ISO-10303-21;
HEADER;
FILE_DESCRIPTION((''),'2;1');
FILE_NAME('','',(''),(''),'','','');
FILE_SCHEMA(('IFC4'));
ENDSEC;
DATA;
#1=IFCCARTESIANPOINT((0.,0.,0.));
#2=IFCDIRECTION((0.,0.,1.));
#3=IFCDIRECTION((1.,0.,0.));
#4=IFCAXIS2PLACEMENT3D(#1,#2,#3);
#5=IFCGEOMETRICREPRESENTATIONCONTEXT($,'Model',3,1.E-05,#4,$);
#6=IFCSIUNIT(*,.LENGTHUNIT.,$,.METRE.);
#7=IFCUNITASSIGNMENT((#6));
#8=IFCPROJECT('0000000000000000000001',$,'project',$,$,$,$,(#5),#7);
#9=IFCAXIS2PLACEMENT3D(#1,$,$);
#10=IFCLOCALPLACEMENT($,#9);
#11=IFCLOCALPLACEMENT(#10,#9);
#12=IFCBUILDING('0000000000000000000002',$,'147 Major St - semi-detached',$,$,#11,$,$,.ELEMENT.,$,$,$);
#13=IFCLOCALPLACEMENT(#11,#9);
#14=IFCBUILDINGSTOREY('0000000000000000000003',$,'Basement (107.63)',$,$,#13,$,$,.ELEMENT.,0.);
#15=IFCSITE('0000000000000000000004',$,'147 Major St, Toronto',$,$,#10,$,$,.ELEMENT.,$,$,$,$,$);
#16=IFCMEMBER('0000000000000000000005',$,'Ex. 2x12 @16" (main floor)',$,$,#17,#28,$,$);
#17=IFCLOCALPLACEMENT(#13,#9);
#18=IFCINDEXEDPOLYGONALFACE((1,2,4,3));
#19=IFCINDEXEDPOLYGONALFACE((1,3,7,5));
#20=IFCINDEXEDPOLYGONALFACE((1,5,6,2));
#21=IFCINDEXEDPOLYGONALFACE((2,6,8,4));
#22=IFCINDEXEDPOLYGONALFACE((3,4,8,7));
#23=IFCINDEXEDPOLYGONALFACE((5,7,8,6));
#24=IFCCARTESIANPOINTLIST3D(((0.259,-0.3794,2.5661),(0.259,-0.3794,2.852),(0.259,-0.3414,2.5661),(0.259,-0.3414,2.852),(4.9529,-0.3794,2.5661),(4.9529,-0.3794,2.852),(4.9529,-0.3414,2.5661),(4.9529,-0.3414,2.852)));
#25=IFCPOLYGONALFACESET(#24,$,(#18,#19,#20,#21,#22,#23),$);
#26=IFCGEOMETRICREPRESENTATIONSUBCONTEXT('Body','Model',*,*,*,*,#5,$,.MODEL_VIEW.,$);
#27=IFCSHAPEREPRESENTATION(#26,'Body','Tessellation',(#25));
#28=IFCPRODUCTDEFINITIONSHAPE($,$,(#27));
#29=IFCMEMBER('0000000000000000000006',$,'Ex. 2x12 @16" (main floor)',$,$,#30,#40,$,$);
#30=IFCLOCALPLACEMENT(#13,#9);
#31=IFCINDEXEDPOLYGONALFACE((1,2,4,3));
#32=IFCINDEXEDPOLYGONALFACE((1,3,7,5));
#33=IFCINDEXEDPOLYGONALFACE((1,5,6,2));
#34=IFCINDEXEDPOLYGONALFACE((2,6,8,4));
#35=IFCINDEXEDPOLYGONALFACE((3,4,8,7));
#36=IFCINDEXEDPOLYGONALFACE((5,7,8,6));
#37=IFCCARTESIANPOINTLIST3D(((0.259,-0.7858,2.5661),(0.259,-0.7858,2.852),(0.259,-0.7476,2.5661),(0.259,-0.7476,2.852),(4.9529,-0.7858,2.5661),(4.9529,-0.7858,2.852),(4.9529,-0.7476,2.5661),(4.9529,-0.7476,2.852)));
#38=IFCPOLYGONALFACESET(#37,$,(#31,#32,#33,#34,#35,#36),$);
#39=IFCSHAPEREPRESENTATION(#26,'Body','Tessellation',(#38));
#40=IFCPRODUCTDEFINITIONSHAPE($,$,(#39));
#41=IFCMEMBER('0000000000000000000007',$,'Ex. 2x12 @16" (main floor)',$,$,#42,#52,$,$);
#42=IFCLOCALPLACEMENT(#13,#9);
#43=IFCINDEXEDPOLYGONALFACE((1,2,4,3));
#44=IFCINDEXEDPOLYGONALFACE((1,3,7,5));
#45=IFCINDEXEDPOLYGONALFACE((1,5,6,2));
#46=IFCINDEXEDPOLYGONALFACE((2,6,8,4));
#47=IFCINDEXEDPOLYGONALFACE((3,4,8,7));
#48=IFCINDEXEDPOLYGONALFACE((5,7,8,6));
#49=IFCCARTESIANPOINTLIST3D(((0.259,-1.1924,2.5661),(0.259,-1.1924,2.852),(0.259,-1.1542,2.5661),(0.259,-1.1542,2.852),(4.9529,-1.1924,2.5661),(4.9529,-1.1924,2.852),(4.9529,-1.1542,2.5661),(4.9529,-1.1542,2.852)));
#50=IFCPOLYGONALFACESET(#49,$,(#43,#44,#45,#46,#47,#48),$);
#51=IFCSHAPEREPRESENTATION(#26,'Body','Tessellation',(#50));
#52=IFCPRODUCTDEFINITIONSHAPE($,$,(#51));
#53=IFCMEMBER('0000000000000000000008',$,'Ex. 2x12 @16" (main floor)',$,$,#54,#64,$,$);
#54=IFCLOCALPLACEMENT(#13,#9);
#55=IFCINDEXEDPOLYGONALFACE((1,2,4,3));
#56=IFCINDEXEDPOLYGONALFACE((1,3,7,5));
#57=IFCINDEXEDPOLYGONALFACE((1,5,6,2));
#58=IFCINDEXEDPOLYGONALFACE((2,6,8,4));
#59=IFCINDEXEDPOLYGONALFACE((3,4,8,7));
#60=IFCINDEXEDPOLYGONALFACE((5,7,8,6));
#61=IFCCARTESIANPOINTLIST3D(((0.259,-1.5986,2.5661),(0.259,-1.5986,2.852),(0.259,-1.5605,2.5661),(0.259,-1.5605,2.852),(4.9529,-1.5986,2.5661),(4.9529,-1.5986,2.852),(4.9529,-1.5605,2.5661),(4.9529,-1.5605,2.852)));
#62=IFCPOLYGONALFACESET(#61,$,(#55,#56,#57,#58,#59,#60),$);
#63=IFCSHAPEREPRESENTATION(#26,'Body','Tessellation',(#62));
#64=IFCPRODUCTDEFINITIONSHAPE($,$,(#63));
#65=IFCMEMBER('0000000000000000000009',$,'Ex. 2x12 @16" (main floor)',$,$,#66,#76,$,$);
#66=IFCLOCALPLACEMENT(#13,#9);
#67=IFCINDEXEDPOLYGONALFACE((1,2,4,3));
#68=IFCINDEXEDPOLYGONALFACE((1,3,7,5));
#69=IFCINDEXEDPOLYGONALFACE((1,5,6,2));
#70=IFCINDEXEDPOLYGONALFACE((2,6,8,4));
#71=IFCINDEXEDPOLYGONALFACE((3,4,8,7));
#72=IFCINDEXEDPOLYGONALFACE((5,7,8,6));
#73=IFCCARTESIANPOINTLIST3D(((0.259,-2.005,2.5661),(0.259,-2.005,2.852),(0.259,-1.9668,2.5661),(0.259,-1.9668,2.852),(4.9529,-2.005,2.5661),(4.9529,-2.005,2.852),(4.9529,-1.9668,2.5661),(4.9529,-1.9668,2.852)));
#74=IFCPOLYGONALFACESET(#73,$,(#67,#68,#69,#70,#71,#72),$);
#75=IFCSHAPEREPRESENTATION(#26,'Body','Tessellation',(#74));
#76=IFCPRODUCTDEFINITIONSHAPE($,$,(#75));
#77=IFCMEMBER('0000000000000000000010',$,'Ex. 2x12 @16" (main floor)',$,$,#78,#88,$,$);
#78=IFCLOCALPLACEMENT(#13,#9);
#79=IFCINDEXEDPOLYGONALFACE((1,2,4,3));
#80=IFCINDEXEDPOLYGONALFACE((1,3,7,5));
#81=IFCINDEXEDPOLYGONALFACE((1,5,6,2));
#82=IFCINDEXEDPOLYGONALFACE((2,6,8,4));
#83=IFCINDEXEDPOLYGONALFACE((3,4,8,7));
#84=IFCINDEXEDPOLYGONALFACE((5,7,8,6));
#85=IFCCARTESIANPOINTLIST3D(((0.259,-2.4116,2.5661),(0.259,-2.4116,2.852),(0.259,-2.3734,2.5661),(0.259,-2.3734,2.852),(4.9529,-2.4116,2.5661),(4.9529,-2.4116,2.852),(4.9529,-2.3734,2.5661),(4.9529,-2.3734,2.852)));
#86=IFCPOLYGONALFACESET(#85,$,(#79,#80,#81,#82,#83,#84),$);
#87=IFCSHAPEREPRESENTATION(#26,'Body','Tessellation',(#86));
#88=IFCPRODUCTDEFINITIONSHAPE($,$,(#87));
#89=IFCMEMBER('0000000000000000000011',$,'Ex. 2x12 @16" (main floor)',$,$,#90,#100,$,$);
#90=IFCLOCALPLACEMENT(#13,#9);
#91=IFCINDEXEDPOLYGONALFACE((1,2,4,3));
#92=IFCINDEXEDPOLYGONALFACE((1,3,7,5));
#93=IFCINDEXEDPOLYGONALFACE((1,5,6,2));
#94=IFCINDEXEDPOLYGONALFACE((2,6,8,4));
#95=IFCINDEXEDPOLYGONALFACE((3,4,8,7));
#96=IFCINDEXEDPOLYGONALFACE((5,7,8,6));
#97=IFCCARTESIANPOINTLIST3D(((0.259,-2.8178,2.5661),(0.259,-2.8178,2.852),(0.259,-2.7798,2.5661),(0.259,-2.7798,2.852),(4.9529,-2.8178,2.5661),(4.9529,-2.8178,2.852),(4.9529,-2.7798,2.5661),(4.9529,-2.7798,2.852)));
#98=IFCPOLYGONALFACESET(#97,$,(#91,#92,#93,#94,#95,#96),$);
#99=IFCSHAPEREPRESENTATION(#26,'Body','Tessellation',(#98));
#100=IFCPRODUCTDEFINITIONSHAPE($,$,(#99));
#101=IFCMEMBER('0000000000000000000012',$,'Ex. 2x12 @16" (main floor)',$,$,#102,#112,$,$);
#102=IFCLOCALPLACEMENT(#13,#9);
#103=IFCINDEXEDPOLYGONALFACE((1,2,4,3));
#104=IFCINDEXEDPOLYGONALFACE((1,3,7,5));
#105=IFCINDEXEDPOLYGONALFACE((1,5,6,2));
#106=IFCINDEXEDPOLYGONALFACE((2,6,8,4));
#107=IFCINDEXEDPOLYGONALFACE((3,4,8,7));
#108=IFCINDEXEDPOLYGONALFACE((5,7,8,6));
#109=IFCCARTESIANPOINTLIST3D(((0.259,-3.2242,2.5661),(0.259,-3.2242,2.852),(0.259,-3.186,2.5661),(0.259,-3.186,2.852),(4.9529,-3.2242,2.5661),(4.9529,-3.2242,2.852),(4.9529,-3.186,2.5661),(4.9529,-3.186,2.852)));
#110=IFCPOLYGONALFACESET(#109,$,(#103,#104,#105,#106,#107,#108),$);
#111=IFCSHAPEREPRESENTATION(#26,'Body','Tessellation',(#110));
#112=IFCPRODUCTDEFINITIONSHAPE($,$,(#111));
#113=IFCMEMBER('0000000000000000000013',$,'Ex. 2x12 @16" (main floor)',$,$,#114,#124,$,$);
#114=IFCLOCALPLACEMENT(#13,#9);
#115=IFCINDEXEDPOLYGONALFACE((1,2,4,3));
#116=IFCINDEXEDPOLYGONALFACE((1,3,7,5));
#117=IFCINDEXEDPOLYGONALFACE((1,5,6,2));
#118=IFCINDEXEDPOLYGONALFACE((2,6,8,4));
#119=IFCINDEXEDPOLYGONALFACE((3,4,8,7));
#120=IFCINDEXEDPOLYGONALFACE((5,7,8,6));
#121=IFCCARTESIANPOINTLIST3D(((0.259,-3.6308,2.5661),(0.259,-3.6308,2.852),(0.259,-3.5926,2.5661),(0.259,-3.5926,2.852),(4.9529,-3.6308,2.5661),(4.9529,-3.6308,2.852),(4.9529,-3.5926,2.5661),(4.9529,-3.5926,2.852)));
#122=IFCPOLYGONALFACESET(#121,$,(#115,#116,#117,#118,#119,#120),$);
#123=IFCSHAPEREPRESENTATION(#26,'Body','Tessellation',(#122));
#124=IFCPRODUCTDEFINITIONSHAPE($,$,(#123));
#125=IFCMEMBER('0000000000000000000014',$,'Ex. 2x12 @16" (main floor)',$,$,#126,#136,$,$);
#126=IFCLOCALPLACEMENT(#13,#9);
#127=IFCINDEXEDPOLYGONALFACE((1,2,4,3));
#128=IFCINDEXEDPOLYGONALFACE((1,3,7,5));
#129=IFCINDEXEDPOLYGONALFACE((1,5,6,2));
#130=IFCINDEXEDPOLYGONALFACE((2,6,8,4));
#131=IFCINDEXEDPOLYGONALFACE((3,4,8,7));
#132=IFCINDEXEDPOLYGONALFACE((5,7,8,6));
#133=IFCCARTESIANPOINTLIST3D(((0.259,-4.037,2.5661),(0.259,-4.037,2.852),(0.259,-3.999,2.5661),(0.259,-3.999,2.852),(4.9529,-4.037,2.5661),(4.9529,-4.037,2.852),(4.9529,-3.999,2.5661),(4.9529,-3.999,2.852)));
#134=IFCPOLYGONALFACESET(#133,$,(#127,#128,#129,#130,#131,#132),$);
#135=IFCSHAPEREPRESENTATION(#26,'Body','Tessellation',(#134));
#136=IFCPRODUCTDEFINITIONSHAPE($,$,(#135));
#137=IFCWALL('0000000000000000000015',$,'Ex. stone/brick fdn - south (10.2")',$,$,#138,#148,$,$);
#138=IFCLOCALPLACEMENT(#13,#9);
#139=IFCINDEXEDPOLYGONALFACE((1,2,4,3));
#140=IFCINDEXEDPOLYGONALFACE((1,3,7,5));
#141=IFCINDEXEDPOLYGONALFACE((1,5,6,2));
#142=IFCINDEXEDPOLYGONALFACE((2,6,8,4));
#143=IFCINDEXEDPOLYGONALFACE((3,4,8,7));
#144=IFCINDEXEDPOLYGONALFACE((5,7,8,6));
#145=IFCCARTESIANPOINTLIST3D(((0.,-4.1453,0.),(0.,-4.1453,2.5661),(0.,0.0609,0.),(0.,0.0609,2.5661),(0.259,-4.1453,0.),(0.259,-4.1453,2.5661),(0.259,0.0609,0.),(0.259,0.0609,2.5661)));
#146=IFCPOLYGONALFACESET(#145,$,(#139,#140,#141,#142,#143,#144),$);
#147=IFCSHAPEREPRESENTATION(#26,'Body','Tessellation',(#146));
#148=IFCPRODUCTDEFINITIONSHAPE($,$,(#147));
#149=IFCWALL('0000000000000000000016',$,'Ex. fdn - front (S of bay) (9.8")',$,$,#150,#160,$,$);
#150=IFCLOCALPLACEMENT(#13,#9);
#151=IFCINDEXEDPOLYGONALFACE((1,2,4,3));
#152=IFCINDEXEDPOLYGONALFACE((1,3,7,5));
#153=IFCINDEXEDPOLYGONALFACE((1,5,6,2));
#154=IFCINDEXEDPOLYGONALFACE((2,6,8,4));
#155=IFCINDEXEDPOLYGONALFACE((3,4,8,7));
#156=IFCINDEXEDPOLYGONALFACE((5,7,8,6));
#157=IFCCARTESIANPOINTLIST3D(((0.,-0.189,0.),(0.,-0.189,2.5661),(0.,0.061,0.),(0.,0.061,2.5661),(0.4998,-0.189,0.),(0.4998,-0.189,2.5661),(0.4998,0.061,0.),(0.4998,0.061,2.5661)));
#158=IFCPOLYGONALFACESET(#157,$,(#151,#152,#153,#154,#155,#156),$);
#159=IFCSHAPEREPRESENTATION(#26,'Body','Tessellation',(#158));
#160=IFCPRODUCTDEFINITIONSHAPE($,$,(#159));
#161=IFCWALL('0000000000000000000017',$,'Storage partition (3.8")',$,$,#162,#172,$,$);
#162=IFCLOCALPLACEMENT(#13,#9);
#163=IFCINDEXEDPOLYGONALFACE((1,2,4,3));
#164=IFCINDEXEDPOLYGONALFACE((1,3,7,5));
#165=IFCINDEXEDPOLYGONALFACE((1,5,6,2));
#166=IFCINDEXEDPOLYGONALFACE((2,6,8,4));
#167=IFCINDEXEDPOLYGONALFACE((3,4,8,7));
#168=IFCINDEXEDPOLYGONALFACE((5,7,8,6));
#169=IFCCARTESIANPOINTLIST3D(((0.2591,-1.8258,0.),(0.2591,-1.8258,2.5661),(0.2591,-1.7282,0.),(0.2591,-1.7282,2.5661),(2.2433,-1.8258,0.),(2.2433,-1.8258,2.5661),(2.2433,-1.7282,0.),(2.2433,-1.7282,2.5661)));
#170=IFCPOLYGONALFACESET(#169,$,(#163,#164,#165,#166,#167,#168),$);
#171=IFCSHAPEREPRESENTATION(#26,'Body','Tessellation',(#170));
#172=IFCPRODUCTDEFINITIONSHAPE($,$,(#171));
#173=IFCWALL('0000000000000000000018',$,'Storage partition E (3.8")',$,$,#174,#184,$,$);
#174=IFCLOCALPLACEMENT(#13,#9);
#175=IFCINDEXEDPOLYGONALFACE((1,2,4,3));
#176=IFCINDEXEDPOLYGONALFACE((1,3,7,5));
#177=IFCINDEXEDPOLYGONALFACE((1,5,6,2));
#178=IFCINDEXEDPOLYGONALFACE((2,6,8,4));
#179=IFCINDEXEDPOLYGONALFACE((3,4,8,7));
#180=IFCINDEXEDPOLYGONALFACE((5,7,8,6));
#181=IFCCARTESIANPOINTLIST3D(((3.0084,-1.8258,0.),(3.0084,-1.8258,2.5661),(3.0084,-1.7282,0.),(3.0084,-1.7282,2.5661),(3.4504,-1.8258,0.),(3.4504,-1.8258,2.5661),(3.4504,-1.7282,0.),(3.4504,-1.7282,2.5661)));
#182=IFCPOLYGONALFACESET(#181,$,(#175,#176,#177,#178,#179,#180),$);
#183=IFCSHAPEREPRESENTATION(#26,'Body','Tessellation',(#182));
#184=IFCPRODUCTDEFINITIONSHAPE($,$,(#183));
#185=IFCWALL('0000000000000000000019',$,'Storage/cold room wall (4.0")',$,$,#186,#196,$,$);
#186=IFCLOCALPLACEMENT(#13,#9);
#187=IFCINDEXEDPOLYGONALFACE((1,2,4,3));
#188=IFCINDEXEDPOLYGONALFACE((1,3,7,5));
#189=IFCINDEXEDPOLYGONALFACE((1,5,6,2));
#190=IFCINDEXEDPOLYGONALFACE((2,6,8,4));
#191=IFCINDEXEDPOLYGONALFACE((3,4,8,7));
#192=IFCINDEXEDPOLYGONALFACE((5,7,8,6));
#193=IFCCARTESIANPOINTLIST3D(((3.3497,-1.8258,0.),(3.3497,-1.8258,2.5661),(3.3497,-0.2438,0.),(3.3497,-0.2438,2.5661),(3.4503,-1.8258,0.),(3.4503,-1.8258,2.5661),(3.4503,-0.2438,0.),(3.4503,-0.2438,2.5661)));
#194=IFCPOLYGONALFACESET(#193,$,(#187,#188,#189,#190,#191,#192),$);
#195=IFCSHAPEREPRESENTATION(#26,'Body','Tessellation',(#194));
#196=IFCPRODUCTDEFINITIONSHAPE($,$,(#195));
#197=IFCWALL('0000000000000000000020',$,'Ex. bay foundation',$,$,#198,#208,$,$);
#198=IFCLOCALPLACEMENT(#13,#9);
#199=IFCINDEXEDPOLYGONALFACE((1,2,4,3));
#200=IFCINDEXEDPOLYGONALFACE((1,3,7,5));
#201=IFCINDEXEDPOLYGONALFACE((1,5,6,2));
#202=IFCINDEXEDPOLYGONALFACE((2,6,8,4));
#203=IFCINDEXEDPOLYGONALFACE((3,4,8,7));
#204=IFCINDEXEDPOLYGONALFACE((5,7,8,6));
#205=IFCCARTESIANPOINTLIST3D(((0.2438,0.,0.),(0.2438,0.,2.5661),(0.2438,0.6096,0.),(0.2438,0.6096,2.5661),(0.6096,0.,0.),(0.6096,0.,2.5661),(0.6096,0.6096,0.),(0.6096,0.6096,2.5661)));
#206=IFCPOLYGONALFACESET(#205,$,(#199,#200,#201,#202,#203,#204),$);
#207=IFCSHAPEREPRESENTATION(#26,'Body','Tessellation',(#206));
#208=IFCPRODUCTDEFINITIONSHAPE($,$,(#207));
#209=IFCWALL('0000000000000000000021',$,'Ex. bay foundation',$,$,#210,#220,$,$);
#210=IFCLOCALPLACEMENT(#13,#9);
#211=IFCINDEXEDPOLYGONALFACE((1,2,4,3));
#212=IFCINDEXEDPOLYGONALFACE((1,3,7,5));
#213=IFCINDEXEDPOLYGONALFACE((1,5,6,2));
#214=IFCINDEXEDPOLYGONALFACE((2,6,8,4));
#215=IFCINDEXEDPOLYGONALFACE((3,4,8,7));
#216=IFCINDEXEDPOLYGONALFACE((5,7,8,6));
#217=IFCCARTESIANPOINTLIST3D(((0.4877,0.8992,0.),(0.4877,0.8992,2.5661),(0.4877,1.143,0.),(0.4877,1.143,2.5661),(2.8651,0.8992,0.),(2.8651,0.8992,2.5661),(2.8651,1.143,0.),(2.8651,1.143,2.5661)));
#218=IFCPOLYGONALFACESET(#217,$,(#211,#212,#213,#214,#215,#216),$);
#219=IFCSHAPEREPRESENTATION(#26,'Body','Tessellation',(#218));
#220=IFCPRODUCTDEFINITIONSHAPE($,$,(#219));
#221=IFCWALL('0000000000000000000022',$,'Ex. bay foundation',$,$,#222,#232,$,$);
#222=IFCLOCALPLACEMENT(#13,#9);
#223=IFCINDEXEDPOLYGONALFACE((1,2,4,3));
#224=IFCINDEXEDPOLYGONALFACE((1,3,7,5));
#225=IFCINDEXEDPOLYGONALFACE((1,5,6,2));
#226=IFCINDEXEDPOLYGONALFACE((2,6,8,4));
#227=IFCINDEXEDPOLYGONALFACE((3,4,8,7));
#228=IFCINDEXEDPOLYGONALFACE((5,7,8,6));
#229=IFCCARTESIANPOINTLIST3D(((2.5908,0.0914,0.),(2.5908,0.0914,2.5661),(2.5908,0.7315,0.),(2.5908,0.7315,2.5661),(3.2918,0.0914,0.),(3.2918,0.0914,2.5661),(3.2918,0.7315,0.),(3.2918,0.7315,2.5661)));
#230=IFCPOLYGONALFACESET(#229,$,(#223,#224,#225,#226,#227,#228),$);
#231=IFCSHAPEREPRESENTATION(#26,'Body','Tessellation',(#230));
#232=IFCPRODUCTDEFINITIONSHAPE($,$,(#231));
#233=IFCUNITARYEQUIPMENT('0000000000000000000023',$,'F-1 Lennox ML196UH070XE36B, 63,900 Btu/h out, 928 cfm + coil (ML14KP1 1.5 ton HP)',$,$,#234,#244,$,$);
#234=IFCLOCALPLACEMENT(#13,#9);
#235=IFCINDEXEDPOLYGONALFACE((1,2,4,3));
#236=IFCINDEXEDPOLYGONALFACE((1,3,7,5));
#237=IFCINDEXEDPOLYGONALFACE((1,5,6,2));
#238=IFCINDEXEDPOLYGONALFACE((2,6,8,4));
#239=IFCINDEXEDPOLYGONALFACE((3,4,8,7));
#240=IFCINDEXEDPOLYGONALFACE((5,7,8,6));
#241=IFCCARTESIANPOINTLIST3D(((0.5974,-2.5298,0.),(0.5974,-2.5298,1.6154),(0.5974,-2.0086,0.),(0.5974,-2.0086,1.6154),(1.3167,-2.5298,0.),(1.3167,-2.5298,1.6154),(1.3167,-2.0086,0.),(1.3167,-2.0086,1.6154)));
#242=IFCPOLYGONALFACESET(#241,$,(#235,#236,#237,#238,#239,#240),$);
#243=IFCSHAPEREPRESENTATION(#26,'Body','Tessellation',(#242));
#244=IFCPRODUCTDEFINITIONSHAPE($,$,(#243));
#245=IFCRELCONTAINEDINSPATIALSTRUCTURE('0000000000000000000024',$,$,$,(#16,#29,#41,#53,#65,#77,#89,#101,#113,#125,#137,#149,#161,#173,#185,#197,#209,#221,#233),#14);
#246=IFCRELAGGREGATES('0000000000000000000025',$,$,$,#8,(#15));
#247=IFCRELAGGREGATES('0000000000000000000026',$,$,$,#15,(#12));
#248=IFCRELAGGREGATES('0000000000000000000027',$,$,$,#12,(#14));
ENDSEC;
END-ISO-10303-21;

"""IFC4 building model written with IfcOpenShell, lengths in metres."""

from ifc_helpers import new_model, si_unit, frame, origin, origin_with_axes, place, context, subcontext, project, spatial, rectangle, extrude, element, save


model = new_model("IFC4")

# Units and contexts
model_context = context("Model", 3, precision=1e-05, world=origin_with_axes())
body_context = subcontext(model_context, "Body", "Model", "MODEL_VIEW")
ifc_project = project(units=[si_unit("LENGTHUNIT", "METRE")], contexts=[model_context])

# Site, building, storey
site_placement = place(None, origin())
site = spatial("IfcSite", under=ifc_project, at=site_placement, Name="147 Major St, Toronto", CompositionType="ELEMENT")
building_placement = place(site_placement, origin())
building = spatial("IfcBuilding", under=site, at=building_placement, Name="147 Major St - semi-detached", CompositionType="ELEMENT")
storey_placement = place(building_placement, origin())
storey = spatial("IfcBuildingStorey", under=building, at=storey_placement, Name="Basement (107.63)", CompositionType="ELEMENT", Elevation=0.0)

# Members
for number, where, name in (
    (1, (2.606, -0.3604, 2.5661), "Ex. 2x12 @16\" (main floor)"),
    (2, (2.606, -0.7667, 2.5661), "Ex. 2x12 @16\" (main floor)"),
    (3, (2.606, -1.1733, 2.5661), "Ex. 2x12 @16\" (main floor)"),
    (4, (2.606, -1.5796, 2.5661), "Ex. 2x12 @16\" (main floor)"),
    (5, (2.606, -1.9859, 2.5661), "Ex. 2x12 @16\" (main floor)"),
    (6, (2.606, -2.3925, 2.5661), "Ex. 2x12 @16\" (main floor)"),
    (7, (2.606, -2.7988, 2.5661), "Ex. 2x12 @16\" (main floor)"),
    (8, (2.606, -3.2051, 2.5661), "Ex. 2x12 @16\" (main floor)"),
    (9, (2.606, -3.6117, 2.5661), "Ex. 2x12 @16\" (main floor)"),
    (10, (2.606, -4.018, 2.5661), "Ex. 2x12 @16\" (main floor)"),
):
    element("IfcMember", number, at=place(storey_placement, frame(where)), inside=storey, Name=name, context=body_context, shape_type="SweptSolid", body=[
        extrude(rectangle(XDim=4.6939, YDim=0.0381), origin_with_axes(), (0.0, 0.0, 1.0), 0.2859),
    ])

# Walls
wall_1_placement = place(storey_placement, frame((0.1295, -2.0422, 0.0)))
element("IfcWall", 11, at=wall_1_placement, inside=storey, Name="Ex. stone/brick fdn - south (10.2\")", context=body_context, shape_type="SweptSolid", body=[
    extrude(rectangle(XDim=0.2591, YDim=4.2062), origin_with_axes(), (0.0, 0.0, 1.0), 2.5661),
])
wall_2_placement = place(storey_placement, frame((0.2499, -0.064, 0.0)))
element("IfcWall", 12, at=wall_2_placement, inside=storey, Name="Ex. fdn - front (S of bay) (9.8\")", context=body_context, shape_type="SweptSolid", body=[
    extrude(rectangle(XDim=0.4999, YDim=0.2499), origin_with_axes(), (0.0, 0.0, 1.0), 2.5661),
])
wall_3_placement = place(storey_placement, frame((1.2512, -1.777, 0.0)))
element("IfcWall", 13, at=wall_3_placement, inside=storey, Name="Storage partition (3.8\")", context=body_context, shape_type="SweptSolid", body=[
    extrude(rectangle(XDim=1.9842, YDim=0.0975), origin_with_axes(), (0.0, 0.0, 1.0), 2.5661),
])
wall_4_placement = place(storey_placement, frame((3.2294, -1.777, 0.0)))
element("IfcWall", 14, at=wall_4_placement, inside=storey, Name="Storage partition E (3.8\")", context=body_context, shape_type="SweptSolid", body=[
    extrude(rectangle(XDim=0.442, YDim=0.0975), origin_with_axes(), (0.0, 0.0, 1.0), 2.5661),
])
wall_5_placement = place(storey_placement, frame((3.4, -1.0348, 0.0)))
element("IfcWall", 15, at=wall_5_placement, inside=storey, Name="Storage/cold room wall (4.0\")", context=body_context, shape_type="SweptSolid", body=[
    extrude(rectangle(XDim=0.1006, YDim=1.5819), origin_with_axes(), (0.0, 0.0, 1.0), 2.5661),
])
wall_6_placement = place(storey_placement, frame((0.4267, 0.3048, 0.0)))
element("IfcWall", 16, at=wall_6_placement, inside=storey, Name="Ex. bay foundation", context=body_context, shape_type="SweptSolid", body=[
    extrude(rectangle(XDim=0.3658, YDim=0.6096), origin_with_axes(), (0.0, 0.0, 1.0), 2.5661),
])
wall_7_placement = place(storey_placement, frame((1.6764, 1.0211, 0.0)))
element("IfcWall", 17, at=wall_7_placement, inside=storey, Name="Ex. bay foundation", context=body_context, shape_type="SweptSolid", body=[
    extrude(rectangle(XDim=2.3774, YDim=0.2438), origin_with_axes(), (0.0, 0.0, 1.0), 2.5661),
])
wall_8_placement = place(storey_placement, frame((2.9413, 0.4115, 0.0)))
element("IfcWall", 18, at=wall_8_placement, inside=storey, Name="Ex. bay foundation", context=body_context, shape_type="SweptSolid", body=[
    extrude(rectangle(XDim=0.701, YDim=0.6401), origin_with_axes(), (0.0, 0.0, 1.0), 2.5661),
])

# Unitary equipment
unitary_equipment_1_placement = place(storey_placement, frame((0.9571, -2.2692, 0.0)))
element("IfcUnitaryEquipment", 19, at=unitary_equipment_1_placement, inside=storey, Name="F-1 Lennox ML196UH070XE36B, 63,900 Btu/h out, 928 cfm + coil (ML14KP1 1.5 ton HP)", context=body_context, shape_type="SweptSolid", body=[
    extrude(rectangle(XDim=0.7193, YDim=0.5212), origin_with_axes(), (0.0, 0.0, 1.0), 1.6154),
])

save(model, "model.ifc")
